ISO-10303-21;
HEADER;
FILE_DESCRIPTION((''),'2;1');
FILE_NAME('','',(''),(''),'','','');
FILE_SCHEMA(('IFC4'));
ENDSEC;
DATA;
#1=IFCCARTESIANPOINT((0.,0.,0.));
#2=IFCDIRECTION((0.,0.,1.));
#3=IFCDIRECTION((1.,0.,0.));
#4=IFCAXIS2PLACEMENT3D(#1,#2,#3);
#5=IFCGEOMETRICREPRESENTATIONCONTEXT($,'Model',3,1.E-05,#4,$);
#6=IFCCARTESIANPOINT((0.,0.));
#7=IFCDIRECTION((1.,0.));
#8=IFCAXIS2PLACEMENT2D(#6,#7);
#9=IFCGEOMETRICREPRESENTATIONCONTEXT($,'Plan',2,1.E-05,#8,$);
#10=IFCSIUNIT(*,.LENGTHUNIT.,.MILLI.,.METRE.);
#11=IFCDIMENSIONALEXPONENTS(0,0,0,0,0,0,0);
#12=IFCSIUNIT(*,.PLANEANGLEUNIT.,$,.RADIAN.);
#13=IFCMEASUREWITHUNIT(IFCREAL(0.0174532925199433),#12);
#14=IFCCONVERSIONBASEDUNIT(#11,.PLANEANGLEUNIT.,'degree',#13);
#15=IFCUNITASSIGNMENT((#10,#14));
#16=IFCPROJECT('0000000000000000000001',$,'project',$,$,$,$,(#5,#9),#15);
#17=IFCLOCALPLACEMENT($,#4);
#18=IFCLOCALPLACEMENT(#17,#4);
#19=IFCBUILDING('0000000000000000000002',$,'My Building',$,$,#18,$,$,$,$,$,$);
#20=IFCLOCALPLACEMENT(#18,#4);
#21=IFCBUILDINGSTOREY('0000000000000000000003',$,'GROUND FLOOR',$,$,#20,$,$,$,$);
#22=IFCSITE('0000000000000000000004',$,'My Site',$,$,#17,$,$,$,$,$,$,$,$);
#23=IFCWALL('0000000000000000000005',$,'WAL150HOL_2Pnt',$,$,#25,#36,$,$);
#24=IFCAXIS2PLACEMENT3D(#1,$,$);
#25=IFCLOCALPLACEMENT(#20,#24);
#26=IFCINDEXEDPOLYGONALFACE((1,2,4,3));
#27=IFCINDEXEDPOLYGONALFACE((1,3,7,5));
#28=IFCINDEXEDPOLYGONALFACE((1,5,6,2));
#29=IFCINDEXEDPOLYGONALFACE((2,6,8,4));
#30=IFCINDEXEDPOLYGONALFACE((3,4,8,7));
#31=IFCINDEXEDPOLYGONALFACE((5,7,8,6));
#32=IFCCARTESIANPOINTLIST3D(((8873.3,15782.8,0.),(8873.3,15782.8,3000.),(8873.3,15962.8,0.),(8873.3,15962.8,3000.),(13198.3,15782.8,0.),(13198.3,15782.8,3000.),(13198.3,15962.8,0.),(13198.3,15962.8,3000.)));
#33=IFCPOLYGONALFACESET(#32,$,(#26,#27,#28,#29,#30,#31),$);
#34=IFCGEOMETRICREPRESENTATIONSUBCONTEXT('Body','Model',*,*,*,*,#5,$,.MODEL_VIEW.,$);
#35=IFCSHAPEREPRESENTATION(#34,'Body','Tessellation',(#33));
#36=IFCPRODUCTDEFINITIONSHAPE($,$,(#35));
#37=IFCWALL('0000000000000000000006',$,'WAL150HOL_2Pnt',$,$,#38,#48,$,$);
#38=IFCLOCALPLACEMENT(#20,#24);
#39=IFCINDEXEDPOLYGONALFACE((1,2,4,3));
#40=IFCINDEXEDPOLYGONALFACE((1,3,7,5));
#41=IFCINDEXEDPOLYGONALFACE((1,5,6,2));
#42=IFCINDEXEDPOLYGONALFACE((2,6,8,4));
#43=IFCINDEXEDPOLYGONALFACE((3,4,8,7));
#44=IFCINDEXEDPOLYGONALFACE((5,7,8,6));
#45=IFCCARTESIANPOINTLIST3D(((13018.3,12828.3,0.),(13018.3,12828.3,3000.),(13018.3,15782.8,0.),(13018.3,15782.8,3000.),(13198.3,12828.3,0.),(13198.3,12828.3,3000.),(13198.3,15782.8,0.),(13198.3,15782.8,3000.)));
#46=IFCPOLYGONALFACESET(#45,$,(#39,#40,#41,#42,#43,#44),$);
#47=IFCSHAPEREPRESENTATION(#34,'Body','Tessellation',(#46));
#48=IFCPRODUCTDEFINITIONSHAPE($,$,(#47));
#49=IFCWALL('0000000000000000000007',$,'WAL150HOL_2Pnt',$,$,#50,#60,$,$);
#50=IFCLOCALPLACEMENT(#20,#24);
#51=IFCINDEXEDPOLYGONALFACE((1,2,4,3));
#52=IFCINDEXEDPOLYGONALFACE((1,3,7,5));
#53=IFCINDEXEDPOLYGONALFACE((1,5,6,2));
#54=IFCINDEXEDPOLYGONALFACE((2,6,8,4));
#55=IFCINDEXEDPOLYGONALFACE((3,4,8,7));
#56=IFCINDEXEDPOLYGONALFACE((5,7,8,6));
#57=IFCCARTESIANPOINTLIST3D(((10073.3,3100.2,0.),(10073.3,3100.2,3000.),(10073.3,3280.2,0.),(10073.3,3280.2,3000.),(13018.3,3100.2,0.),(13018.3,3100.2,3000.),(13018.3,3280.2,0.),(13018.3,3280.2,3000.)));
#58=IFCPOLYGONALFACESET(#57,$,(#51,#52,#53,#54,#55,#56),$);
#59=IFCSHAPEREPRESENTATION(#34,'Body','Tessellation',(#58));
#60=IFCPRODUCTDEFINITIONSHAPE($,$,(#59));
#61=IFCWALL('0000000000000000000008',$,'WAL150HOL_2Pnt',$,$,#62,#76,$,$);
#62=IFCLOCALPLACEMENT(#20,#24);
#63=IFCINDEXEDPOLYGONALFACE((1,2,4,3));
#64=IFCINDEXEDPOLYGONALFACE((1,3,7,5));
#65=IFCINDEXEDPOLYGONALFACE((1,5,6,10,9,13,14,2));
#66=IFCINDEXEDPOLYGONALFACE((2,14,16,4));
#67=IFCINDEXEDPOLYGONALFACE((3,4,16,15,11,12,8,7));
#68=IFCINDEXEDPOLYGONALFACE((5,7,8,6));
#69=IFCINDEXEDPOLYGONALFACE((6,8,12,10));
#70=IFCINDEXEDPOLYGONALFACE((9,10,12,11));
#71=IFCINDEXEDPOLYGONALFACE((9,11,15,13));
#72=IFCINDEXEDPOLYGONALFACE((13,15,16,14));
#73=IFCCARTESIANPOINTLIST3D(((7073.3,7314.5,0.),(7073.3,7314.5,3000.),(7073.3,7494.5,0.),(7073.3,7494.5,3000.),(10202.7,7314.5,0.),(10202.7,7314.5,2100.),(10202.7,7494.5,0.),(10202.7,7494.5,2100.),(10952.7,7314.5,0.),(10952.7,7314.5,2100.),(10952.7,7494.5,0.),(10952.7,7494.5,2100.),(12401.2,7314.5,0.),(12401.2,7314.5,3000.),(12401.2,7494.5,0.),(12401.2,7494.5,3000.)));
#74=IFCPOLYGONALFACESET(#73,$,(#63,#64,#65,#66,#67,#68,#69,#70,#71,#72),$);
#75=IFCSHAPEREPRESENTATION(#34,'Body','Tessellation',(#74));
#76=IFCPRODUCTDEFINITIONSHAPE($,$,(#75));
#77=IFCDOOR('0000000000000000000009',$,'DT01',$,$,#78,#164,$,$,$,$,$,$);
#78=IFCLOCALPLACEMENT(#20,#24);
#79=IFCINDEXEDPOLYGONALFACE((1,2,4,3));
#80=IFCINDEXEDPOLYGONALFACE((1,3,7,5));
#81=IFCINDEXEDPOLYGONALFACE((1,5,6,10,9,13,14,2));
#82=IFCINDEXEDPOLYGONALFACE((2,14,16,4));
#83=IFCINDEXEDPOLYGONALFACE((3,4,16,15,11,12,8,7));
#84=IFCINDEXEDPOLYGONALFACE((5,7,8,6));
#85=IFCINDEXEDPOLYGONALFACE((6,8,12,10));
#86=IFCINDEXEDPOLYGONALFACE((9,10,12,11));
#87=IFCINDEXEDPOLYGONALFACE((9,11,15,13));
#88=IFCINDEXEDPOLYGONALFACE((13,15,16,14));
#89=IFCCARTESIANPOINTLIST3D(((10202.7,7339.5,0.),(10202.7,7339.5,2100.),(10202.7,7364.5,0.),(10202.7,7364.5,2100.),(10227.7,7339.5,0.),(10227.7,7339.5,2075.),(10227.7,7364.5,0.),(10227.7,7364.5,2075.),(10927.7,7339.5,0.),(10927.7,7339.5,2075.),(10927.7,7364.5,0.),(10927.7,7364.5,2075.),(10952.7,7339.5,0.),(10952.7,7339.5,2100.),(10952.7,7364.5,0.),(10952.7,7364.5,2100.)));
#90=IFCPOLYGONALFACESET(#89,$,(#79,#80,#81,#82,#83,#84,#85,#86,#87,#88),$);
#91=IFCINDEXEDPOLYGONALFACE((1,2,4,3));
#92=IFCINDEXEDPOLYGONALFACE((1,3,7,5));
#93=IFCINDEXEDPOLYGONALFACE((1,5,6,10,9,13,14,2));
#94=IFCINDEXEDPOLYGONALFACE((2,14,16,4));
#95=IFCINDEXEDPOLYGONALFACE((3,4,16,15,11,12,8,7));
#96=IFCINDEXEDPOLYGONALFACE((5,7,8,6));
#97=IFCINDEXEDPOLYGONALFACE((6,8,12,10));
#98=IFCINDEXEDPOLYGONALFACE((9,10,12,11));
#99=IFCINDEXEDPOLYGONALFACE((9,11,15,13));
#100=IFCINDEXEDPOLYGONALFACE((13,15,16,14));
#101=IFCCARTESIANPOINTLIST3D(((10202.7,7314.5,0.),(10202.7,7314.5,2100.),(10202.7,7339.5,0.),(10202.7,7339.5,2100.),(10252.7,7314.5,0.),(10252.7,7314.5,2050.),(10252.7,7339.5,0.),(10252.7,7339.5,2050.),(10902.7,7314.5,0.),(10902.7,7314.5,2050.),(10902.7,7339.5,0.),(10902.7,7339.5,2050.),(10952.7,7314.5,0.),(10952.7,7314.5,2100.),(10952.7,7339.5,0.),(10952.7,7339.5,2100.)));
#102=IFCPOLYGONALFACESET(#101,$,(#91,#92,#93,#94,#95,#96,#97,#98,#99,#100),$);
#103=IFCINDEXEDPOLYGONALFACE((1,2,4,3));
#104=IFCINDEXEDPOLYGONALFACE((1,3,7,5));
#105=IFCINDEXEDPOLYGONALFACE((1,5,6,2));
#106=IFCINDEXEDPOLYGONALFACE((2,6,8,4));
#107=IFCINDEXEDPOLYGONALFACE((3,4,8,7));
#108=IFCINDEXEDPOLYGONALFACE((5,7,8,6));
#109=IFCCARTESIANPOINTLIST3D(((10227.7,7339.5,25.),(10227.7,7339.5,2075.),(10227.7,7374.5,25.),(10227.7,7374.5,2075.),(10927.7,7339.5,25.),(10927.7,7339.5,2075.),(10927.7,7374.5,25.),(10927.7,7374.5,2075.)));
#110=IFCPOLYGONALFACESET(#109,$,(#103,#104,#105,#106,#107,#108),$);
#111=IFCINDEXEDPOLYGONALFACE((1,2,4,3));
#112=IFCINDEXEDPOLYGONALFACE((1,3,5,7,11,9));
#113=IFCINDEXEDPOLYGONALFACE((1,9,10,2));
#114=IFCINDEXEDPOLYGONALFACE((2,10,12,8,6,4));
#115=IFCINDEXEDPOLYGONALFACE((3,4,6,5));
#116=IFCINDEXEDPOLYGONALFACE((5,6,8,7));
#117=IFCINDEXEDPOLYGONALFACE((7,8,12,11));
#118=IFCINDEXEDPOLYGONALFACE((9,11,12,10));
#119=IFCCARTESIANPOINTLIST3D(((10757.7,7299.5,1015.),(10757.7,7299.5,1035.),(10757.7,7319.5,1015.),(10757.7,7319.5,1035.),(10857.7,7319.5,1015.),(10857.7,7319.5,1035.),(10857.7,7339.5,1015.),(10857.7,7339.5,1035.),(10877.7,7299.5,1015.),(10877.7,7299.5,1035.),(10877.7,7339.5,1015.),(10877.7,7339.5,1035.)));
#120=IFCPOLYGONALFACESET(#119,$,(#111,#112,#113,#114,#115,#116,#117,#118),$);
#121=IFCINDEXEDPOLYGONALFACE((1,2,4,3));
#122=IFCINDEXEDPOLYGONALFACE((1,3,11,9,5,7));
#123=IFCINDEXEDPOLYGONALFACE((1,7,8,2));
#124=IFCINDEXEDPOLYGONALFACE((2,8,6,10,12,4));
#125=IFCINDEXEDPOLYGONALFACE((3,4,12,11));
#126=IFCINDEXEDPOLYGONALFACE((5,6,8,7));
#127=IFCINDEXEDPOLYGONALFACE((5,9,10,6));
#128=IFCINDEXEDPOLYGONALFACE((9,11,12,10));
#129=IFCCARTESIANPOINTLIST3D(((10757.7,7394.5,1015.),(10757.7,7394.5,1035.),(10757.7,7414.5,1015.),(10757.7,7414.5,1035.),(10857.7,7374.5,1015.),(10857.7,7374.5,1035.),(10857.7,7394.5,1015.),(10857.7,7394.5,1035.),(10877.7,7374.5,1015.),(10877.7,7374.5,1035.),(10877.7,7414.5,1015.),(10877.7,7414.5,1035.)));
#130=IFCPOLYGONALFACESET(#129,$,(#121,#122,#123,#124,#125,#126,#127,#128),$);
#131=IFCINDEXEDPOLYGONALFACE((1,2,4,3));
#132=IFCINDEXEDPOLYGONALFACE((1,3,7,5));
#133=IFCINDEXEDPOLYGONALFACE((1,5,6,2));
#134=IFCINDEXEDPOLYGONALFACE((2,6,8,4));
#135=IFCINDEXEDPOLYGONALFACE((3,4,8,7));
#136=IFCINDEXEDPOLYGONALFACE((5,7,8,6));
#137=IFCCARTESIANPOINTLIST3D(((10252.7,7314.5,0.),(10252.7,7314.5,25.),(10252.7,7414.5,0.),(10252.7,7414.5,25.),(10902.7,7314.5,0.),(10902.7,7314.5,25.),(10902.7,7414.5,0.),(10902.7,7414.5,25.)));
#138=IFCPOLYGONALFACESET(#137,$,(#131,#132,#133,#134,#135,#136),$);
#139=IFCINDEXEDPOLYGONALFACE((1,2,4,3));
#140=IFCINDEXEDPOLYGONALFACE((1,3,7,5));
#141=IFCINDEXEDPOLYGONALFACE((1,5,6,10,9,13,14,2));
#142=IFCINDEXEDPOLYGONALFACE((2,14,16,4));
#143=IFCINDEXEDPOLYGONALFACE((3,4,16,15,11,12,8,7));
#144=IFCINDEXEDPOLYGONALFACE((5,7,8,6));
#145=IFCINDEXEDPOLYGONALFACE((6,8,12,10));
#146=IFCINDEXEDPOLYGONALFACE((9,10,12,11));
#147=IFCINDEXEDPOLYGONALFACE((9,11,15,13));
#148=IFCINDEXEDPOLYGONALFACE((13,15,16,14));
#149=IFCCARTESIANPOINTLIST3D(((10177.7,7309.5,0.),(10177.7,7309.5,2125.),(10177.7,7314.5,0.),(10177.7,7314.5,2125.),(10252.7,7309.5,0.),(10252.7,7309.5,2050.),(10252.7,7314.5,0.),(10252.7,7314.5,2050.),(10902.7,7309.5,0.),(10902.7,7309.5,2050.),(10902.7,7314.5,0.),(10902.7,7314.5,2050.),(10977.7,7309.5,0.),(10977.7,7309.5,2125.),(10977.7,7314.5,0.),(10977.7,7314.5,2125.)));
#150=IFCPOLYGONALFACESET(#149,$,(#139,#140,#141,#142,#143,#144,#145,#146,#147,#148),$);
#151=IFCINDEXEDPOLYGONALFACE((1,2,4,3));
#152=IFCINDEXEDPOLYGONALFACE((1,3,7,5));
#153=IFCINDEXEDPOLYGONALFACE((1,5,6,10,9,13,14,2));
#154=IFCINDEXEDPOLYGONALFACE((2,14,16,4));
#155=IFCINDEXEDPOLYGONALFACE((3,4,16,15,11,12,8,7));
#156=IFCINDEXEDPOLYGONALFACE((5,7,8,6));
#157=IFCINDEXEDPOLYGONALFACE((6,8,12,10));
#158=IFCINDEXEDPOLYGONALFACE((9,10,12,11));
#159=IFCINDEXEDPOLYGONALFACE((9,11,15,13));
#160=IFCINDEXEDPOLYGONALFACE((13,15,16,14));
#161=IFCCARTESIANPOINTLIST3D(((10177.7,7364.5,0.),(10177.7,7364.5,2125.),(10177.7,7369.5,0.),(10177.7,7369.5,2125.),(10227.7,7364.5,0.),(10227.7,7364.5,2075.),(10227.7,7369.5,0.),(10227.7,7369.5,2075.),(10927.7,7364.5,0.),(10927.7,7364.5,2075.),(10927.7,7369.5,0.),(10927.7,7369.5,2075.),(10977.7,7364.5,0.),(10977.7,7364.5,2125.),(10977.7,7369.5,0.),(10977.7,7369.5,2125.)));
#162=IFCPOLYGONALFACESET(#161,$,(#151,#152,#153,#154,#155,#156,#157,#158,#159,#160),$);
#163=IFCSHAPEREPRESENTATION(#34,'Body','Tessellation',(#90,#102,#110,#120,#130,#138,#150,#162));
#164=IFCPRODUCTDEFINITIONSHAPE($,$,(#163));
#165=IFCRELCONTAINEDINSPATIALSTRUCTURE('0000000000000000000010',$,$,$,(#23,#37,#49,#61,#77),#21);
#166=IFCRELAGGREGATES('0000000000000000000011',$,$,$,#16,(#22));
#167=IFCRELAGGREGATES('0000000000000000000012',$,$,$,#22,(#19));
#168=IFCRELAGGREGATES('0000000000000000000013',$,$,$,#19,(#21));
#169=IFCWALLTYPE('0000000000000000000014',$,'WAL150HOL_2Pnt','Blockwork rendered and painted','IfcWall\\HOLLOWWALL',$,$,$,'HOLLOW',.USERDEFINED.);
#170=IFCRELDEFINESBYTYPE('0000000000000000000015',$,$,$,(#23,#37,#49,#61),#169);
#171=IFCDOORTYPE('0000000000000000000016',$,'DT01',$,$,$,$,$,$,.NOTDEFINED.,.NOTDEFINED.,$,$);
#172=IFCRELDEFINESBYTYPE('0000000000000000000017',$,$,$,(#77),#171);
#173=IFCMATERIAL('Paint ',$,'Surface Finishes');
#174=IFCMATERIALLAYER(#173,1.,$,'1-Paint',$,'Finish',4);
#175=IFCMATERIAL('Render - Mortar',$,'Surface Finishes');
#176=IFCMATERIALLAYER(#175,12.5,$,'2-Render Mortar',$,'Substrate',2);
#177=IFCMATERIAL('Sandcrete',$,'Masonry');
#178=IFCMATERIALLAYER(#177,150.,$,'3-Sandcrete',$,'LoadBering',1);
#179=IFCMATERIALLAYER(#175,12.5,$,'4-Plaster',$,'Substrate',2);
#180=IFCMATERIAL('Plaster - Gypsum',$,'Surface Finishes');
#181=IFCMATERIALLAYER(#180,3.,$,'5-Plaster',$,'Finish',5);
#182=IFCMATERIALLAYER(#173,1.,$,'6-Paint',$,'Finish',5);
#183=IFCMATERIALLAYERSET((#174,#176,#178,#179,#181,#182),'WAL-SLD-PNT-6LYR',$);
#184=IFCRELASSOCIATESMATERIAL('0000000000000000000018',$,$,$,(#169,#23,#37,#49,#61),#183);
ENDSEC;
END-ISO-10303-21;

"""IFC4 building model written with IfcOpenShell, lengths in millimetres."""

from ifc_helpers import new_model, entity, si_unit, converted_unit, frame, origin_with_axes, origin_2d_with_axis, place, context, subcontext, project, spatial, line, indexed_curve, outline, extrude, shape, source, transform, mapped, material, layer, layer_set, layer_usage, type_object, type_shapes, element, fill, save


model = new_model("IFC4")

# Units and contexts
model_context = context("Model", 3, precision=1e-05, world=origin_with_axes())
plan_context = context("Plan", 2, precision=1e-05, world=origin_2d_with_axis())
body_context_1 = subcontext(model_context, "Body", "Model", "MODEL_VIEW")
body_context_2 = subcontext(plan_context, "Body", "Plan", "PLAN_VIEW")
ifc_project = project(units=[si_unit("LENGTHUNIT", "METRE", prefix="MILLI"), converted_unit("PLANEANGLEUNIT", "degree", entity("IfcReal", 0.0174532925199433), si_unit("PLANEANGLEUNIT", "RADIAN"), dimensions=[0, 0, 0, 0, 0, 0, 0])], contexts=[model_context, plan_context])

# Site, building, storey
site_placement = place(None, origin_with_axes())
site = spatial("IfcSite", under=ifc_project, at=site_placement, Name="My Site")
building_placement = place(site_placement, origin_with_axes())
building = spatial("IfcBuilding", under=site, at=building_placement, Name="My Building")
storey_placement = place(building_placement, origin_with_axes())
storey = spatial("IfcBuildingStorey", under=building, at=storey_placement, Name="GROUND FLOOR")

# Shared definitions
ifc_material_1 = material(Name="Paint ", Category="Surface Finishes")
ifc_layer_1 = layer(ifc_material_1, 1.0, Name="1-Paint", Category="Finish", Priority=4)
ifc_material_2 = material(Name="Render - Mortar", Category="Surface Finishes")
ifc_layer_2 = layer(ifc_material_2, 12.5, Name="2-Render Mortar", Category="Substrate", Priority=2)
ifc_material_3 = material(Name="Sandcrete", Category="Masonry")
ifc_layer_3 = layer(ifc_material_3, 150.0, Name="3-Sandcrete", Category="LoadBering", Priority=1)
ifc_layer_4 = layer(ifc_material_2, 12.5, Name="4-Plaster", Category="Substrate", Priority=2)
ifc_material_4 = material(Name="Plaster - Gypsum", Category="Surface Finishes")
ifc_layer_5 = layer(ifc_material_4, 3.0, Name="5-Plaster", Category="Finish", Priority=5)
ifc_layer_6 = layer(ifc_material_1, 1.0, Name="6-Paint", Category="Finish", Priority=5)
ifc_layer_set_1 = layer_set([ifc_layer_1, ifc_layer_2, ifc_layer_3, ifc_layer_4, ifc_layer_5, ifc_layer_6], Name="WAL-SLD-PNT-6LYR")
wall_type_1 = type_object("IfcWallType", Name="WAL150HOL_2Pnt", Description="Blockwork rendered and painted", ApplicableOccurrence="IfcWall\\HOLLOWWALL", ElementType="HOLLOW", PredefinedType="USERDEFINED", material=ifc_layer_set_1)

# Walls
ifc_layer_usage_1 = layer_usage(ifc_layer_set_1, "AXIS2", "POSITIVE", 0.0)
wall_1_placement = place(storey_placement, frame((13198.3, 15962.8, 0.0), z_axis=(0.0, 0.0, 1.0), x_axis=(-1.0, 0.000001, 0.0)))
element("IfcWall", 1, at=wall_1_placement, inside=storey, type_object=wall_type_1, material=ifc_layer_usage_1, Name="WAL150HOL_2Pnt", context=body_context_1, shape_type="SweptSolid", body=[
    extrude(outline(indexed_curve([(0.0, 0.0), (0.0, 180.0), (4325.0, 180.0), (4325.0, 0.0), (0.0, 0.0)], self_intersect=False)), origin_with_axes(), (0.0, 0.0, 1.0), 3000.0),
])
ifc_layer_usage_2 = layer_usage(ifc_layer_set_1, "AXIS2", "POSITIVE", 0.0)
wall_2_placement = place(storey_placement, frame((13198.3, 12828.3, 0.0), z_axis=(0.0, 0.0, 1.0), x_axis=(0.000001, 1.0, 0.0)))
element("IfcWall", 2, at=wall_2_placement, inside=storey, type_object=wall_type_1, material=ifc_layer_usage_2, Name="WAL150HOL_2Pnt", context=body_context_1, shape_type="SweptSolid", body=[
    extrude(outline(indexed_curve([(0.0, 0.0), (0.0, 180.0), (2954.5, 180.0), (2954.5, 0.0), (0.0, 0.0)], self_intersect=False)), origin_with_axes(), (0.0, 0.0, 1.0), 3000.0),
])
ifc_layer_usage_3 = layer_usage(ifc_layer_set_1, "AXIS2", "POSITIVE", 0.0)
wall_3_placement = place(storey_placement, frame((10073.3, 3100.2, 0.0), z_axis=(0.0, 0.0, 1.0), x_axis=(1.0, -0.000001, 0.0)))
element("IfcWall", 3, at=wall_3_placement, inside=storey, type_object=wall_type_1, material=ifc_layer_usage_3, Name="WAL150HOL_2Pnt", context=body_context_1, shape_type="SweptSolid", body=[
    extrude(outline(indexed_curve([(0.0, 0.0), (0.0, 180.0), (2945.0, 180.0), (2945.0, 0.0), (0.0, 0.0)], self_intersect=False)), origin_with_axes(), (0.0, 0.0, 1.0), 3000.0),
])

# Wall, opening, door
ifc_layer_usage_4 = layer_usage(ifc_layer_set_1, "AXIS2", "POSITIVE", 0.0)
wall_4_placement = place(storey_placement, frame((7073.3, 7314.5, 0.0), z_axis=(0.0, 0.0, 1.0), x_axis=(1.0, 0.0, 0.0)))
wall_4 = element("IfcWall", 4, at=wall_4_placement, inside=storey, type_object=wall_type_1, material=ifc_layer_usage_4, Name="WAL150HOL_2Pnt", context=body_context_1, shape_type="SweptSolid", body=[
    extrude(outline(indexed_curve([(0.0, 0.0), (0.0, 180.0), (5327.9, 180.0), (5327.9, 0.0), (0.0, 0.0)], self_intersect=False)), origin_with_axes(), (0.0, 0.0, 1.0), 3000.0),
])
shared_shape_1 = source(origin_with_axes(), body_context_1, "Body", "SweptSolid", [
    extrude(outline(indexed_curve([(0.0, 0.0), (750.0, 0.0), (750.0, 2100.0), (0.0, 2100.0)], segments=[line(1, 2, 3, 4, 1)])), frame((0.0, -100.0, 0.0), z_axis=(0.0, -1.0, 0.0), x_axis=(1.0, 0.0, 0.0)), (0.0, 0.0, -1.0), 380.0),
])
opening_1_placement = place(wall_4_placement, frame((3129.4, 0.0, 0.0), z_axis=(0.0, 0.0, 1.0), x_axis=(1.0, 0.0, 0.0)))
opening_1 = element("IfcOpeningElement", 5, at=opening_1_placement, cuts=wall_4, PredefinedType="OPENING", context=body_context_1, shape_type="MappedRepresentation", body=[
    mapped(shared_shape_1, transform((0.0, 0.0, 0.0), x_axis=(1.0, 0.0, 0.0), y_axis=(0.0, 1.0, 0.0), z_axis=(0.0, 0.0, 1.0), scale=1.0)),
])
door_type_1 = type_object("IfcDoorType", Name="DT01", OperationType="NOTDEFINED", PredefinedType="NOTDEFINED")
shared_shape_2 = source(origin_with_axes(), body_context_1, "Body", "SweptSolid", [
    extrude(outline(indexed_curve([(0.0, 0.0), (0.0, 2100.0), (750.0, 2100.0), (750.0, 0.0), (725.0, 0.0), (725.0, 2075.0), (25.0, 2075.0), (25.0, 0.0)], segments=[line(1, 2, 3, 4, 5, 6, 7, 8, 1)])), frame((0.0, 25.0, 0.0), z_axis=(0.0, -1.0, 0.0), x_axis=(1.0, 0.0, 0.0)), (0.0, 0.0, -1.0), 25.0),
    extrude(outline(indexed_curve([(0.0, 0.0), (0.0, 2100.0), (750.0, 2100.0), (750.0, 0.0), (700.0, 0.0), (700.0, 2050.0), (50.0, 2050.0), (50.0, 0.0)], segments=[line(1, 2, 3, 4, 5, 6, 7, 8, 1)])), frame((0.0, 0.0, 0.0), z_axis=(0.0, -1.0, 0.0), x_axis=(1.0, 0.0, 0.0)), (0.0, 0.0, -1.0), 25.0),
    extrude(outline(indexed_curve([(0.0, 0.0), (700.0, 0.0), (700.0, 35.0), (0.0, 35.0)], segments=[line(1, 2, 3, 4, 1)])), frame((25.0, 25.0, 25.0), z_axis=(0.0, 0.0, 1.0), x_axis=(1.0, 0.0, 0.0)), (0.0, 0.0, 1.0), 2050.0),
    extrude(outline(indexed_curve([(0.0, 0.0), (0.0, -40.0), (-120.0, -40.0), (-120.0, -20.0), (-20.0, -20.0), (-20.0, 0.0)], segments=[line(1, 2, 3, 4, 5, 6, 1)])), frame((675.0, 25.0, 1015.0), z_axis=(0.0, 0.0, 1.0), x_axis=(1.0, 0.0, 0.0)), (0.0, 0.0, 1.0), 20.0),
    extrude(outline(indexed_curve([(0.0, 0.0), (0.0, 40.0), (-120.0, 40.0), (-120.0, 20.0), (-20.0, 20.0), (-20.0, 0.0)], segments=[line(1, 2, 3, 4, 5, 6, 1)])), frame((675.0, 60.0, 1015.0), z_axis=(0.0, 0.0, 1.0), x_axis=(1.0, 0.0, 0.0)), (0.0, 0.0, 1.0), 20.0),
    extrude(outline(indexed_curve([(0.0, 0.0), (650.0, 0.0), (650.0, 100.0), (0.0, 100.0)], segments=[line(1, 2, 3, 4, 1)])), frame((50.0, 0.0, 0.0), z_axis=(0.0, 0.0, 1.0), x_axis=(1.0, 0.0, 0.0)), (0.0, 0.0, 1.0), 25.0),
    extrude(outline(indexed_curve([(0.0, 0.0), (0.0, 2125.0), (800.0, 2125.0), (800.0, 0.0), (725.0, 0.0), (725.0, 2050.0), (75.0, 2050.0), (75.0, 0.0)], segments=[line(1, 2, 3, 4, 5, 6, 7, 8, 1)])), frame((-25.0, -5.0, 0.0), z_axis=(0.0, -1.0, 0.0), x_axis=(1.0, 0.0, 0.0)), (0.0, 0.0, -1.0), 5.0),
    extrude(outline(indexed_curve([(0.0, 0.0), (0.0, 2125.0), (800.0, 2125.0), (800.0, 0.0), (750.0, 0.0), (750.0, 2075.0), (50.0, 2075.0), (50.0, 0.0)], segments=[line(1, 2, 3, 4, 5, 6, 7, 8, 1)])), frame((-25.0, 50.0, 0.0), z_axis=(0.0, -1.0, 0.0), x_axis=(1.0, 0.0, 0.0)), (0.0, 0.0, -1.0), 5.0),
])
shared_shape_3 = source(origin_with_axes(), body_context_2, "Body", "Curve2D", [
    entity("IfcIndexedPolyCurve", entity("IfcCartesianPointList2D", [[0.0, 0.0], [0.0, 50.0], [25.0, 50.0], [25.0, 25.0], [50.0, 25.0], [50.0, 0.0]]), [entity("IfcLineIndex", [1, 2, 3, 4, 5, 6, 1])]),
    entity("IfcIndexedPolyCurve", entity("IfcCartesianPointList2D", [[750.0, 0.0], [750.0, 50.0], [725.0, 50.0], [725.0, 25.0], [700.0, 25.0], [700.0, 0.0]]), [entity("IfcLineIndex", [1, 2, 3, 4, 5, 6, 1])]),
    entity("IfcTrimmedCurve", entity("IfcEllipse", entity("IfcAxis2Placement2D", entity("IfcCartesianPoint", [60.0, 50.0]), entity("IfcDirection", [1.0, 0.0])), 665.0, 700.0), [entity("IfcCartesianPoint", [725.0, 50.0])], [entity("IfcCartesianPoint", [60.0, 750.0])], True, "CARTESIAN"),
    entity("IfcIndexedPolyCurve", entity("IfcCartesianPointList2D", [[25.0, 50.0], [60.0, 50.0], [60.0, 750.0], [25.0, 750.0]]), [entity("IfcLineIndex", [1, 2, 3, 4, 1])]),
])
type_shapes(door_type_1, [shared_shape_2, shared_shape_3])
door_1_placement = place(storey_placement, frame((10202.7, 7314.5, 0.0), z_axis=(0.0, 0.0, 1.0), x_axis=(1.0, 0.0, 0.0)))
door_1 = element("IfcDoor", 6, at=door_1_placement, inside=storey, type_object=door_type_1, Name="DT01", shapes=[
    shape(body_context_1, "Body", "MappedRepresentation", [mapped(shared_shape_2, transform((0.0, 0.0, 0.0), x_axis=(1.0, 0.0, 0.0), y_axis=(0.0, 1.0, 0.0), z_axis=(0.0, 0.0, 1.0), scale=1.0))]),
    shape(body_context_2, "Body", "MappedRepresentation", [mapped(shared_shape_3, transform((0.0, 0.0, 0.0), x_axis=(1.0, 0.0, 0.0), y_axis=(0.0, 1.0, 0.0), z_axis=(0.0, 0.0, 1.0), scale=1.0))]),
])
fill(opening_1, door_1)

save(model, "model.ifc")
